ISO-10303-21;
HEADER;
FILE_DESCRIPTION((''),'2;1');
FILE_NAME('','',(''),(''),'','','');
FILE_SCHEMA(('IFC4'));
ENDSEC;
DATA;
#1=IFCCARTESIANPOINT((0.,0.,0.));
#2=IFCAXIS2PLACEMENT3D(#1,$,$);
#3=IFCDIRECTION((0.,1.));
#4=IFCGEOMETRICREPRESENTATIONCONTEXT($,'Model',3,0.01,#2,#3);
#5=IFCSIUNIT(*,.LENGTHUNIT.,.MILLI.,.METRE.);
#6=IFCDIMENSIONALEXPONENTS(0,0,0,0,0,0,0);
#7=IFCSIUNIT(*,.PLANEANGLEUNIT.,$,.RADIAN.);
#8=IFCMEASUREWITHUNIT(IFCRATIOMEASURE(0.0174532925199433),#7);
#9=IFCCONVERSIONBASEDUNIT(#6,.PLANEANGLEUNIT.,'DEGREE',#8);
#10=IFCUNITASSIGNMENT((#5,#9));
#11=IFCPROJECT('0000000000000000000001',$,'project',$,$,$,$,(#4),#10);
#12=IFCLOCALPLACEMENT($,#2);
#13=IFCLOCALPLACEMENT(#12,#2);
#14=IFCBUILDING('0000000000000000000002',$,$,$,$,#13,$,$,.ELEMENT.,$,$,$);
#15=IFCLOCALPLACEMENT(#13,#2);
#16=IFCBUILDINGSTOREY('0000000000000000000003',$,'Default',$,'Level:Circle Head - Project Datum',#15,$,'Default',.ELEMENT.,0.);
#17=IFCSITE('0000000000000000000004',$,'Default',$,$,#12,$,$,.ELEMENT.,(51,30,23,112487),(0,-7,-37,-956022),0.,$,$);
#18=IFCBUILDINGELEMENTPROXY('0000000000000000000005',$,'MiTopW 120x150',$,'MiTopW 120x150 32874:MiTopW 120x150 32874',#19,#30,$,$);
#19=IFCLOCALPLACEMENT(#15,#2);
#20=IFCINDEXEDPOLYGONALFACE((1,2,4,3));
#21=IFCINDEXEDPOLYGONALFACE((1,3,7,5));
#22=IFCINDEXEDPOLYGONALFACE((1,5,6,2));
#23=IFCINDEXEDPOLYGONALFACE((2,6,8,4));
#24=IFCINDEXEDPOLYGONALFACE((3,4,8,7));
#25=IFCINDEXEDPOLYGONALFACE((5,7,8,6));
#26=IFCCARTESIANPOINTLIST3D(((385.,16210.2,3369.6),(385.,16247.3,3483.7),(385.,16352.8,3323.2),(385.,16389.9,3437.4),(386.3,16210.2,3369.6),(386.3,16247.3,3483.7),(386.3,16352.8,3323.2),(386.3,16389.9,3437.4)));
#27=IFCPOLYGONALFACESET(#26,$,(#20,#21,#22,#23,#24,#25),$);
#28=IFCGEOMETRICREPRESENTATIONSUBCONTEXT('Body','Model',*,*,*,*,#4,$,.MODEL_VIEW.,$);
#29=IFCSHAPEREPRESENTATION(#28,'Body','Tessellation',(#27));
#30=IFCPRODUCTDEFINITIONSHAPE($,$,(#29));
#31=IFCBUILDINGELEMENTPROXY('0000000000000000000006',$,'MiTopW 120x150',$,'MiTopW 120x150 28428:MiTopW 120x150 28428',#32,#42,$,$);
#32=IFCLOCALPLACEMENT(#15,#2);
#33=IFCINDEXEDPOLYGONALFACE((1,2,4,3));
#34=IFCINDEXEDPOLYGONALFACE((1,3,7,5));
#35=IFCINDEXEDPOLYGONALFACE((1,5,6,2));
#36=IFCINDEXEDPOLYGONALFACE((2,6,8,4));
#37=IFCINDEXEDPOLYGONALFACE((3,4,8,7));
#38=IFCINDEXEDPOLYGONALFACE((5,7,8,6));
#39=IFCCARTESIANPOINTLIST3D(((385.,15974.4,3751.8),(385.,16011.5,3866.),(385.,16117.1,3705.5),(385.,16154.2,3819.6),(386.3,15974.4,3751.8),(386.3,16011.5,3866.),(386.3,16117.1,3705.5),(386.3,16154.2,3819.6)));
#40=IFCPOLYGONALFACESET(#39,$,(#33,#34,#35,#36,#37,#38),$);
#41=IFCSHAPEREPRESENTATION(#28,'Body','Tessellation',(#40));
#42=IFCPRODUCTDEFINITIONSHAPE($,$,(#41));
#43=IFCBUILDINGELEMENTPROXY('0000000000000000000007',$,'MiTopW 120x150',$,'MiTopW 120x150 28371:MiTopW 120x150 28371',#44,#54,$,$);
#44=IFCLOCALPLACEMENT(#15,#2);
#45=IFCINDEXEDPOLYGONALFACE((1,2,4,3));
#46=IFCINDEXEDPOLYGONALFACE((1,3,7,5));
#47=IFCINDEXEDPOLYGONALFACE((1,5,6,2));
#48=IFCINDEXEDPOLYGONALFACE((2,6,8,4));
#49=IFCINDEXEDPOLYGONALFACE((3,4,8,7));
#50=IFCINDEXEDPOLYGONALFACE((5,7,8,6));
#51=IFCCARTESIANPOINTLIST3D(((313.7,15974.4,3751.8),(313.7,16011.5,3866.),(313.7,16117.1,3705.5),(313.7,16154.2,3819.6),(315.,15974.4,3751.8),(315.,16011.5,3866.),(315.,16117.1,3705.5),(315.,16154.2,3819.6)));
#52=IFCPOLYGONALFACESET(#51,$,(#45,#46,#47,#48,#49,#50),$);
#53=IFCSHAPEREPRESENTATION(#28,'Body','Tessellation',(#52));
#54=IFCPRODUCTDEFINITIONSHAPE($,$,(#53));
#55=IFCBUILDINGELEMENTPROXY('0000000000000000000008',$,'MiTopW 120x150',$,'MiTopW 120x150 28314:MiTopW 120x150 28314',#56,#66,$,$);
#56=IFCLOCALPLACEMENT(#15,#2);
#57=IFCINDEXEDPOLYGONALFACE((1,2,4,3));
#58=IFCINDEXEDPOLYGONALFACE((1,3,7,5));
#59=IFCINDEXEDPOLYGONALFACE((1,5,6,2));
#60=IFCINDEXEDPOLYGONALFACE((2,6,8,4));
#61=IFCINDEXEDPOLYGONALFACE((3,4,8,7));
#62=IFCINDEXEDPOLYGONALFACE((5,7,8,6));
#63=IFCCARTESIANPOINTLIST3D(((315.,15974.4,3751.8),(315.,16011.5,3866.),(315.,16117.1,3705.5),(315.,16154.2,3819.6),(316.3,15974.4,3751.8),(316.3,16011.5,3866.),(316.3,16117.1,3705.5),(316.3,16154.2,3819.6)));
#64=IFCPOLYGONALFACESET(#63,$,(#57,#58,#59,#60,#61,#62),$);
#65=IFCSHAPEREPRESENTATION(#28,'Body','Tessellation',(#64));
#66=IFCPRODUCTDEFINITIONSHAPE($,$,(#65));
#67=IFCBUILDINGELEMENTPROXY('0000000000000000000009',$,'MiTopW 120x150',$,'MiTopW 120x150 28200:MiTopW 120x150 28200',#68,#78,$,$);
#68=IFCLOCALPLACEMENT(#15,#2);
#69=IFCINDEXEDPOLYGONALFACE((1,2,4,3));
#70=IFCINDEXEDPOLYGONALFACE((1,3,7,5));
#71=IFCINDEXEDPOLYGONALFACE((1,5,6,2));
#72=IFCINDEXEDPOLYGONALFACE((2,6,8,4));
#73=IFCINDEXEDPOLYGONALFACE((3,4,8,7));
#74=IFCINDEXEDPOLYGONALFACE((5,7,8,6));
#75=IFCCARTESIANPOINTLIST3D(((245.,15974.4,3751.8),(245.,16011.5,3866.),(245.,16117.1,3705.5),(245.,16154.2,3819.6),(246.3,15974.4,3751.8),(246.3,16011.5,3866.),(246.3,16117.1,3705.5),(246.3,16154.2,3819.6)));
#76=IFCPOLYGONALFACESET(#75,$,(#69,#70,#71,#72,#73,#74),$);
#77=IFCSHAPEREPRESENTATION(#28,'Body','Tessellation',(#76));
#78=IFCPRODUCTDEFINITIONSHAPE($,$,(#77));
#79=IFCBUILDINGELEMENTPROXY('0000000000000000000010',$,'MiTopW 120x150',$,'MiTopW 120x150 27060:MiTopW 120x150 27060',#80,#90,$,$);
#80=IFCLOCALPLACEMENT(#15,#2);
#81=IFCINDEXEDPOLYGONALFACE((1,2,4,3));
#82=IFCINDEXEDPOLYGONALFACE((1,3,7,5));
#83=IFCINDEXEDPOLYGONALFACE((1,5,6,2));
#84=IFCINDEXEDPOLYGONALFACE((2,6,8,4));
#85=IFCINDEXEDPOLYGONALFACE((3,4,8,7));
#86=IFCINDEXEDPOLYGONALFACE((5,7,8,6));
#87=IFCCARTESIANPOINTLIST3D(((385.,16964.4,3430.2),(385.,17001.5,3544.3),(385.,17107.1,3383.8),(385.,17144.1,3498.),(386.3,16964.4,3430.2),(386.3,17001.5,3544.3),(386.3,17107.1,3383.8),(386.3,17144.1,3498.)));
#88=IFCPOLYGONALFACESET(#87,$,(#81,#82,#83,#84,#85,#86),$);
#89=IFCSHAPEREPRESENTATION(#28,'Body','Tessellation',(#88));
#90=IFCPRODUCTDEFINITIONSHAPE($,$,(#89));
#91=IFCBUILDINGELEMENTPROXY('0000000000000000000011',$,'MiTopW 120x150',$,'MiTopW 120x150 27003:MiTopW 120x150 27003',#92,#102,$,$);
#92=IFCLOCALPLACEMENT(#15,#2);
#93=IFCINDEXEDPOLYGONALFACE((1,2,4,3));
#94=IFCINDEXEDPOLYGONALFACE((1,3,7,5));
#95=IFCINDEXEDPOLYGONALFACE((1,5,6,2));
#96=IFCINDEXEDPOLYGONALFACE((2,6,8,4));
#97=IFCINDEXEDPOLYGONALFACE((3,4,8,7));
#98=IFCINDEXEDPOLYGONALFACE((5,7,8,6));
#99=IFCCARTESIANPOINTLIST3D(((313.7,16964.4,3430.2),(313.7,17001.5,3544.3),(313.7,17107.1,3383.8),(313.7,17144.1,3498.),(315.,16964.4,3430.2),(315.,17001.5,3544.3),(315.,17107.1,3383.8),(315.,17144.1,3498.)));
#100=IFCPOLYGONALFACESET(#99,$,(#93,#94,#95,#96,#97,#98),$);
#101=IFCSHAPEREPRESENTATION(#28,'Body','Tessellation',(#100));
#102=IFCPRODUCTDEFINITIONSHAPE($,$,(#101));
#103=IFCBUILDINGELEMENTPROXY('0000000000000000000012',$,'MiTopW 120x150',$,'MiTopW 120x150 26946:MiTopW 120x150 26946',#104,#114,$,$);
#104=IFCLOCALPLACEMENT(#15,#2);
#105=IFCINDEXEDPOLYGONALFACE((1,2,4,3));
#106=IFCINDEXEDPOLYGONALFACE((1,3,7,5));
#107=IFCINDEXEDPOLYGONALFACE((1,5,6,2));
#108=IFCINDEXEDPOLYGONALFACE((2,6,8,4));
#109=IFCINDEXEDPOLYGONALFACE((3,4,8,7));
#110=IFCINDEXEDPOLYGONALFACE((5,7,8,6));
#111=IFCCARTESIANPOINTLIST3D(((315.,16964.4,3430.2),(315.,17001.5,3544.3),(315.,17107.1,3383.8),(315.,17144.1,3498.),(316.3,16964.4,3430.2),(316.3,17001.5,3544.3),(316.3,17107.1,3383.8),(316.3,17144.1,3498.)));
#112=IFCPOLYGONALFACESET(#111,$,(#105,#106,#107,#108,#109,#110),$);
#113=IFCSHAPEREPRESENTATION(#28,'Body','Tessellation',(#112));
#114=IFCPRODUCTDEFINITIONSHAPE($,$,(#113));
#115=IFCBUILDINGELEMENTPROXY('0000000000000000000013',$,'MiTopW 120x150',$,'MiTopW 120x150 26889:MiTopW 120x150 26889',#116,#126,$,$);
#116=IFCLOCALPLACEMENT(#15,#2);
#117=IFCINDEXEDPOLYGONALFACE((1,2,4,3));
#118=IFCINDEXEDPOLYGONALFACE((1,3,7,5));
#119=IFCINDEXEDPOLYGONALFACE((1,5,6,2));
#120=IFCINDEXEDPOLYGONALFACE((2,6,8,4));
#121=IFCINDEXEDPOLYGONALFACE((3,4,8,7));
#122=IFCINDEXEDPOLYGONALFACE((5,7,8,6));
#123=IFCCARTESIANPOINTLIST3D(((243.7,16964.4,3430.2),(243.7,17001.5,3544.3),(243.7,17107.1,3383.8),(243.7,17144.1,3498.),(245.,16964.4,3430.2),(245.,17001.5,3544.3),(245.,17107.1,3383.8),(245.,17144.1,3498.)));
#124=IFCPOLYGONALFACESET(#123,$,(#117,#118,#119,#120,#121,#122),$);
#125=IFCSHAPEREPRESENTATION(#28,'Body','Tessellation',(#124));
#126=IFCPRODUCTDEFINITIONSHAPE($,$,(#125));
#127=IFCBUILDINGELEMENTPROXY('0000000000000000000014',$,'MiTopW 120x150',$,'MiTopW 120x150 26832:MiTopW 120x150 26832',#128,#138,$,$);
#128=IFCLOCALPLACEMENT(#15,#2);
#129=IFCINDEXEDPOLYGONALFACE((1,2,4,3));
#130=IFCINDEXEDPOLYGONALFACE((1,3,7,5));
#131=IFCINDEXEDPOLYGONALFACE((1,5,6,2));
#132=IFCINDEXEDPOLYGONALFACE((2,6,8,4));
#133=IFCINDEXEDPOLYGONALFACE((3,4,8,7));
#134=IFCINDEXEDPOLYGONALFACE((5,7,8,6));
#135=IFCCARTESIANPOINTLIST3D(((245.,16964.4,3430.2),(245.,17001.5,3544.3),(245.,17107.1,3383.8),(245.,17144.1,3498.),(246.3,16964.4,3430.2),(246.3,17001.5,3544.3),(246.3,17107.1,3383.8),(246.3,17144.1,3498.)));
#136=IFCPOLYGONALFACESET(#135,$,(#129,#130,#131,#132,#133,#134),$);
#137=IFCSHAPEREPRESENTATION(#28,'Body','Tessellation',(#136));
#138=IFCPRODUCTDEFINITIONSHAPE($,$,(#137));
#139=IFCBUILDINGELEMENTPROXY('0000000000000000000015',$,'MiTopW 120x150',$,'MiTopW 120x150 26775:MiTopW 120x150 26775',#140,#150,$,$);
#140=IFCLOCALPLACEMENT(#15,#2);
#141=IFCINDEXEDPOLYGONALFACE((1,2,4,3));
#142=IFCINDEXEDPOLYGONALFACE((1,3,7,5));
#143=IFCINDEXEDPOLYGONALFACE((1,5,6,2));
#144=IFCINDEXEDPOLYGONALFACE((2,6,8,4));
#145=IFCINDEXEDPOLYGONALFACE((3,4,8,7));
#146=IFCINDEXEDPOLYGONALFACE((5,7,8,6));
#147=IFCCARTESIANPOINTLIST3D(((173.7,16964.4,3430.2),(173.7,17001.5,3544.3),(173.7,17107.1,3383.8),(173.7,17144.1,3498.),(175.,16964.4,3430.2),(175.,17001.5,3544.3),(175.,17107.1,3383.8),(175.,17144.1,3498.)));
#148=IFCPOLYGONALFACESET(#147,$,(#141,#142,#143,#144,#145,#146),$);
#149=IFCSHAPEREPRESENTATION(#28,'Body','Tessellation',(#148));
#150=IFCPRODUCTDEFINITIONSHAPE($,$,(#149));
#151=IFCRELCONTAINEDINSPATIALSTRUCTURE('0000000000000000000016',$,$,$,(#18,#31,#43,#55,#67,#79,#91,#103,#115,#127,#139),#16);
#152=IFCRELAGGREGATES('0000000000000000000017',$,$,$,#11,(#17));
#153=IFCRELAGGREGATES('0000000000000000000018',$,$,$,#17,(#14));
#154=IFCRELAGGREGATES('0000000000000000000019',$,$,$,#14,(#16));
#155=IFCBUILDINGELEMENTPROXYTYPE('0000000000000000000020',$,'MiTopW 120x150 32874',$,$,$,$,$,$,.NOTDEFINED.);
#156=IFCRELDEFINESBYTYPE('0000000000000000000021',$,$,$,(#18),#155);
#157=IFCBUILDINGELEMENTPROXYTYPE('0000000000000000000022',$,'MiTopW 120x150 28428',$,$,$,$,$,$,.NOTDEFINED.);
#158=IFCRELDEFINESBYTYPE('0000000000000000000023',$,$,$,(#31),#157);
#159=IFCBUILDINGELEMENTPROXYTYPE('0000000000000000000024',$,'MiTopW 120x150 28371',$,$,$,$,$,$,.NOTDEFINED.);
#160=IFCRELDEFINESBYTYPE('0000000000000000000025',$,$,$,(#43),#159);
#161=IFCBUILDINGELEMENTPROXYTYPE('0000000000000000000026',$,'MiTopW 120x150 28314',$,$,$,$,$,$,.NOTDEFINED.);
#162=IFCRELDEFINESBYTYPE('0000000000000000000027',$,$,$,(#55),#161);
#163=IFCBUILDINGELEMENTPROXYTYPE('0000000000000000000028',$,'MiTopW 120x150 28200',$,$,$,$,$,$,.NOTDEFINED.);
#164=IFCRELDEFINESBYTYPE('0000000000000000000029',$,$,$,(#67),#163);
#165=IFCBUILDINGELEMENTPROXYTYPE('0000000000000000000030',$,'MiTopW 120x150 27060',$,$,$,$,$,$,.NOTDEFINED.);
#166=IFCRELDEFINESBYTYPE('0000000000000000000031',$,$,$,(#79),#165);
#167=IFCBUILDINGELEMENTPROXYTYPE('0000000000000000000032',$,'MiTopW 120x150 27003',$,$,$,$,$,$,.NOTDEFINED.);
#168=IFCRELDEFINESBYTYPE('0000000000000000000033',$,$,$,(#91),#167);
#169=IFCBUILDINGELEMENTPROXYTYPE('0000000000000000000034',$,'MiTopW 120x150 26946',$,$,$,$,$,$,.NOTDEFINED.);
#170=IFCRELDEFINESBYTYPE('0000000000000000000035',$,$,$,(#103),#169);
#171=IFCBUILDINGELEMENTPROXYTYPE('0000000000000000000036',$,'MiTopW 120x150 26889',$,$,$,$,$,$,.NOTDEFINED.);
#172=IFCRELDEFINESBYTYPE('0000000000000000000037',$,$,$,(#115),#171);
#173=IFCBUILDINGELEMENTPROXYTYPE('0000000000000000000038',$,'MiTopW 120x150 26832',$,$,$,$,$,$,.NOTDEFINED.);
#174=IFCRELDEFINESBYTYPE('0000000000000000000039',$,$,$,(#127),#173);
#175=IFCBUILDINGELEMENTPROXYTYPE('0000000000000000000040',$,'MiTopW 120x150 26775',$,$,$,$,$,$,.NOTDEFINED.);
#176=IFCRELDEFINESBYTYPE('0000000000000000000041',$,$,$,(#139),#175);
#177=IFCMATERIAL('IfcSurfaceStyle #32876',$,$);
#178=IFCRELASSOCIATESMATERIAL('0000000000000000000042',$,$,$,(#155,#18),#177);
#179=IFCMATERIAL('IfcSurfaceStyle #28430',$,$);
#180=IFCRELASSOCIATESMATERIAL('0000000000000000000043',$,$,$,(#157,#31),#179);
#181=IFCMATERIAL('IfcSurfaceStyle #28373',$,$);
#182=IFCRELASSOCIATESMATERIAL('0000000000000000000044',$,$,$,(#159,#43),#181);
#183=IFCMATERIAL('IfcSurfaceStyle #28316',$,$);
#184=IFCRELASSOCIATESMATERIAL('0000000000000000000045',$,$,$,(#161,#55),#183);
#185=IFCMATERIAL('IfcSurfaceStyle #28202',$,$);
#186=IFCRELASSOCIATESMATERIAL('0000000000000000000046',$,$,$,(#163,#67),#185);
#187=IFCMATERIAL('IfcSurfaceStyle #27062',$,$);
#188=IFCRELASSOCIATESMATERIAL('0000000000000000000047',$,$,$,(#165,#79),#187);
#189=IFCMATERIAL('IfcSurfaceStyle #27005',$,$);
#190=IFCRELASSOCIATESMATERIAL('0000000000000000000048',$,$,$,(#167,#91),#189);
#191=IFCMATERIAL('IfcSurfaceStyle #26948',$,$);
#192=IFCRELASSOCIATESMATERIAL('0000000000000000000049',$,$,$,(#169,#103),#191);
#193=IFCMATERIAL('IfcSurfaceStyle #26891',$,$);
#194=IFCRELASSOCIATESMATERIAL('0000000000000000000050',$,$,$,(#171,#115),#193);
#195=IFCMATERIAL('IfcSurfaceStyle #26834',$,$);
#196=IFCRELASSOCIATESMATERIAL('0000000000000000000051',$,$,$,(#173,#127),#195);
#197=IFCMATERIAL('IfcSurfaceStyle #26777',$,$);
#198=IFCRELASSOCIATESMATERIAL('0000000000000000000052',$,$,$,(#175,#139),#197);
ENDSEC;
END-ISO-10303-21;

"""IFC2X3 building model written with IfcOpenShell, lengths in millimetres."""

from ifc_helpers import new_model, entity, si_unit, converted_unit, direction, frame, origin, place, context, subcontext, project, spatial, polyline, outline, extrude, source, transform, mapped, material, type_object, type_shapes, element, save


model = new_model("IFC2X3")

# Units and contexts
model_context = context("Model", 3, precision=0.01, world=origin(), true_north=direction((0.0, 1.0)))
body_context = subcontext(model_context, "Body", "Model", "MODEL_VIEW")
ifc_project = project(units=[si_unit("LENGTHUNIT", "METRE", prefix="MILLI"), converted_unit("PLANEANGLEUNIT", "DEGREE", entity("IfcRatioMeasure", 0.0174532925199433), si_unit("PLANEANGLEUNIT", "RADIAN"), dimensions=[0, 0, 0, 0, 0, 0, 0])], contexts=[model_context])

# Site, building, storey
site_placement = place(None, origin())
site = spatial("IfcSite", under=ifc_project, at=site_placement, Name="Default", CompositionType="ELEMENT", RefLatitude=(51, 30, 23, 112487), RefLongitude=(0, -7, -37, -956022), RefElevation=0.0)
building_placement = place(site_placement, origin())
building = spatial("IfcBuilding", under=site, at=building_placement, CompositionType="ELEMENT")
storey_placement = place(building_placement, origin())
storey = spatial("IfcBuildingStorey", under=building, at=storey_placement, Name="Default", ObjectType="Level:Circle Head - Project Datum", LongName="Default", CompositionType="ELEMENT", Elevation=0.0)

# Building element proxies
ifc_material_1 = material(Name="IfcSurfaceStyle #32876")
building_element_proxy_type_1 = type_object("IfcBuildingElementProxyType", Name="MiTopW 120x150 32874", PredefinedType="NOTDEFINED", material=ifc_material_1)
shared_shape_1 = source(origin(), body_context, "Body", "SweptSolid", [
    extrude(outline(polyline([(-75.0, -60.0), (75.0, -60.0), (75.0, 60.0), (-75.0, 60.0), (-75.0, -60.0)])), frame((75.0, 60.0, 0.0), z_axis=(0.0, 0.0, 1.0), x_axis=(-1.0, 0.0, 0.0)), (0.0, 0.0, 1.0), 1.3),
])
type_shapes(building_element_proxy_type_1, [shared_shape_1])
proxy_1_placement = place(building_placement, frame((386.3, 16352.8, 3323.2), z_axis=(-1.0, 0.0, 0.0), x_axis=(0.0, -0.951057, 0.309017)))
element("IfcBuildingElementProxy", 1, at=proxy_1_placement, inside=storey, type_object=building_element_proxy_type_1, material=ifc_material_1, Name="MiTopW 120x150", ObjectType="MiTopW 120x150 32874:MiTopW 120x150 32874", context=body_context, shape_type="MappedRepresentation", body=[
    mapped(shared_shape_1, transform((0.0, 0.0, 0.0), scale=1.0)),
])
ifc_material_2 = material(Name="IfcSurfaceStyle #28430")
building_element_proxy_type_2 = type_object("IfcBuildingElementProxyType", Name="MiTopW 120x150 28428", PredefinedType="NOTDEFINED", material=ifc_material_2)
shared_shape_2 = source(origin(), body_context, "Body", "SweptSolid", [
    extrude(outline(polyline([(-75.0, -60.0), (75.0, -60.0), (75.0, 60.0), (-75.0, 60.0), (-75.0, -60.0)])), frame((75.0, 60.0, 0.0), z_axis=(0.0, 0.0, 1.0), x_axis=(-1.0, 0.0, 0.0)), (0.0, 0.0, 1.0), 1.3),
])
type_shapes(building_element_proxy_type_2, [shared_shape_2])
proxy_2_placement = place(building_placement, frame((386.3, 16117.1, 3705.5), z_axis=(-1.0, 0.0, 0.0), x_axis=(0.0, -0.951057, 0.309017)))
element("IfcBuildingElementProxy", 2, at=proxy_2_placement, inside=storey, type_object=building_element_proxy_type_2, material=ifc_material_2, Name="MiTopW 120x150", ObjectType="MiTopW 120x150 28428:MiTopW 120x150 28428", context=body_context, shape_type="MappedRepresentation", body=[
    mapped(shared_shape_2, transform((0.0, 0.0, 0.0), scale=1.0)),
])
ifc_material_3 = material(Name="IfcSurfaceStyle #28373")
building_element_proxy_type_3 = type_object("IfcBuildingElementProxyType", Name="MiTopW 120x150 28371", PredefinedType="NOTDEFINED", material=ifc_material_3)
shared_shape_3 = source(origin(), body_context, "Body", "SweptSolid", [
    extrude(outline(polyline([(-75.0, -60.0), (75.0, -60.0), (75.0, 60.0), (-75.0, 60.0), (-75.0, -60.0)])), frame((75.0, 60.0, 0.0), z_axis=(0.0, 0.0, 1.0), x_axis=(-1.0, 0.0, 0.0)), (0.0, 0.0, 1.0), 1.3),
])
type_shapes(building_element_proxy_type_3, [shared_shape_3])
proxy_3_placement = place(building_placement, frame((315.0, 16117.1, 3705.5), z_axis=(-1.0, 0.0, 0.0), x_axis=(0.0, -0.951057, 0.309017)))
element("IfcBuildingElementProxy", 3, at=proxy_3_placement, inside=storey, type_object=building_element_proxy_type_3, material=ifc_material_3, Name="MiTopW 120x150", ObjectType="MiTopW 120x150 28371:MiTopW 120x150 28371", context=body_context, shape_type="MappedRepresentation", body=[
    mapped(shared_shape_3, transform((0.0, 0.0, 0.0), scale=1.0)),
])
ifc_material_4 = material(Name="IfcSurfaceStyle #28316")
building_element_proxy_type_4 = type_object("IfcBuildingElementProxyType", Name="MiTopW 120x150 28314", PredefinedType="NOTDEFINED", material=ifc_material_4)
shared_shape_4 = source(origin(), body_context, "Body", "SweptSolid", [
    extrude(outline(polyline([(-75.0, -60.0), (75.0, -60.0), (75.0, 60.0), (-75.0, 60.0), (-75.0, -60.0)])), frame((75.0, 60.0, 0.0), z_axis=(0.0, 0.0, 1.0), x_axis=(-1.0, 0.0, 0.0)), (0.0, 0.0, 1.0), 1.3),
])
type_shapes(building_element_proxy_type_4, [shared_shape_4])
proxy_4_placement = place(building_placement, frame((316.3, 16117.1, 3705.5), z_axis=(-1.0, 0.0, 0.0), x_axis=(0.0, -0.951057, 0.309017)))
element("IfcBuildingElementProxy", 4, at=proxy_4_placement, inside=storey, type_object=building_element_proxy_type_4, material=ifc_material_4, Name="MiTopW 120x150", ObjectType="MiTopW 120x150 28314:MiTopW 120x150 28314", context=body_context, shape_type="MappedRepresentation", body=[
    mapped(shared_shape_4, transform((0.0, 0.0, 0.0), scale=1.0)),
])
ifc_material_5 = material(Name="IfcSurfaceStyle #28202")
building_element_proxy_type_5 = type_object("IfcBuildingElementProxyType", Name="MiTopW 120x150 28200", PredefinedType="NOTDEFINED", material=ifc_material_5)
shared_shape_5 = source(origin(), body_context, "Body", "SweptSolid", [
    extrude(outline(polyline([(-75.0, -60.0), (75.0, -60.0), (75.0, 60.0), (-75.0, 60.0), (-75.0, -60.0)])), frame((75.0, 60.0, 0.0), z_axis=(0.0, 0.0, 1.0), x_axis=(-1.0, 0.0, 0.0)), (0.0, 0.0, 1.0), 1.3),
])
type_shapes(building_element_proxy_type_5, [shared_shape_5])
proxy_5_placement = place(building_placement, frame((246.3, 16117.1, 3705.5), z_axis=(-1.0, 0.0, 0.0), x_axis=(0.0, -0.951057, 0.309017)))
element("IfcBuildingElementProxy", 5, at=proxy_5_placement, inside=storey, type_object=building_element_proxy_type_5, material=ifc_material_5, Name="MiTopW 120x150", ObjectType="MiTopW 120x150 28200:MiTopW 120x150 28200", context=body_context, shape_type="MappedRepresentation", body=[
    mapped(shared_shape_5, transform((0.0, 0.0, 0.0), scale=1.0)),
])
ifc_material_6 = material(Name="IfcSurfaceStyle #27062")
building_element_proxy_type_6 = type_object("IfcBuildingElementProxyType", Name="MiTopW 120x150 27060", PredefinedType="NOTDEFINED", material=ifc_material_6)
shared_shape_6 = source(origin(), body_context, "Body", "SweptSolid", [
    extrude(outline(polyline([(-75.0, -60.0), (75.0, -60.0), (75.0, 60.0), (-75.0, 60.0), (-75.0, -60.0)])), frame((75.0, 60.0, 0.0), z_axis=(0.0, 0.0, 1.0), x_axis=(-1.0, 0.0, 0.0)), (0.0, 0.0, 1.0), 1.3),
])
type_shapes(building_element_proxy_type_6, [shared_shape_6])
proxy_6_placement = place(building_placement, frame((386.3, 17107.1, 3383.8), z_axis=(-1.0, 0.0, 0.0), x_axis=(0.0, -0.951057, 0.309017)))
element("IfcBuildingElementProxy", 6, at=proxy_6_placement, inside=storey, type_object=building_element_proxy_type_6, material=ifc_material_6, Name="MiTopW 120x150", ObjectType="MiTopW 120x150 27060:MiTopW 120x150 27060", context=body_context, shape_type="MappedRepresentation", body=[
    mapped(shared_shape_6, transform((0.0, 0.0, 0.0), scale=1.0)),
])
ifc_material_7 = material(Name="IfcSurfaceStyle #27005")
building_element_proxy_type_7 = type_object("IfcBuildingElementProxyType", Name="MiTopW 120x150 27003", PredefinedType="NOTDEFINED", material=ifc_material_7)
shared_shape_7 = source(origin(), body_context, "Body", "SweptSolid", [
    extrude(outline(polyline([(-75.0, -60.0), (75.0, -60.0), (75.0, 60.0), (-75.0, 60.0), (-75.0, -60.0)])), frame((75.0, 60.0, 0.0), z_axis=(0.0, 0.0, 1.0), x_axis=(-1.0, 0.0, 0.0)), (0.0, 0.0, 1.0), 1.3),
])
type_shapes(building_element_proxy_type_7, [shared_shape_7])
proxy_7_placement = place(building_placement, frame((315.0, 17107.1, 3383.8), z_axis=(-1.0, 0.0, 0.0), x_axis=(0.0, -0.951057, 0.309017)))
element("IfcBuildingElementProxy", 7, at=proxy_7_placement, inside=storey, type_object=building_element_proxy_type_7, material=ifc_material_7, Name="MiTopW 120x150", ObjectType="MiTopW 120x150 27003:MiTopW 120x150 27003", context=body_context, shape_type="MappedRepresentation", body=[
    mapped(shared_shape_7, transform((0.0, 0.0, 0.0), scale=1.0)),
])
ifc_material_8 = material(Name="IfcSurfaceStyle #26948")
building_element_proxy_type_8 = type_object("IfcBuildingElementProxyType", Name="MiTopW 120x150 26946", PredefinedType="NOTDEFINED", material=ifc_material_8)
shared_shape_8 = source(origin(), body_context, "Body", "SweptSolid", [
    extrude(outline(polyline([(-75.0, -60.0), (75.0, -60.0), (75.0, 60.0), (-75.0, 60.0), (-75.0, -60.0)])), frame((75.0, 60.0, 0.0), z_axis=(0.0, 0.0, 1.0), x_axis=(-1.0, 0.0, 0.0)), (0.0, 0.0, 1.0), 1.3),
])
type_shapes(building_element_proxy_type_8, [shared_shape_8])
proxy_8_placement = place(building_placement, frame((316.3, 17107.1, 3383.8), z_axis=(-1.0, 0.0, 0.0), x_axis=(0.0, -0.951057, 0.309017)))
element("IfcBuildingElementProxy", 8, at=proxy_8_placement, inside=storey, type_object=building_element_proxy_type_8, material=ifc_material_8, Name="MiTopW 120x150", ObjectType="MiTopW 120x150 26946:MiTopW 120x150 26946", context=body_context, shape_type="MappedRepresentation", body=[
    mapped(shared_shape_8, transform((0.0, 0.0, 0.0), scale=1.0)),
])
ifc_material_9 = material(Name="IfcSurfaceStyle #26891")
building_element_proxy_type_9 = type_object("IfcBuildingElementProxyType", Name="MiTopW 120x150 26889", PredefinedType="NOTDEFINED", material=ifc_material_9)
shared_shape_9 = source(origin(), body_context, "Body", "SweptSolid", [
    extrude(outline(polyline([(-75.0, -60.0), (75.0, -60.0), (75.0, 60.0), (-75.0, 60.0), (-75.0, -60.0)])), frame((75.0, 60.0, 0.0), z_axis=(0.0, 0.0, 1.0), x_axis=(-1.0, 0.0, 0.0)), (0.0, 0.0, 1.0), 1.3),
])
type_shapes(building_element_proxy_type_9, [shared_shape_9])
proxy_9_placement = place(building_placement, frame((245.0, 17107.1, 3383.8), z_axis=(-1.0, 0.0, 0.0), x_axis=(0.0, -0.951057, 0.309017)))
element("IfcBuildingElementProxy", 9, at=proxy_9_placement, inside=storey, type_object=building_element_proxy_type_9, material=ifc_material_9, Name="MiTopW 120x150", ObjectType="MiTopW 120x150 26889:MiTopW 120x150 26889", context=body_context, shape_type="MappedRepresentation", body=[
    mapped(shared_shape_9, transform((0.0, 0.0, 0.0), scale=1.0)),
])
ifc_material_10 = material(Name="IfcSurfaceStyle #26834")
building_element_proxy_type_10 = type_object("IfcBuildingElementProxyType", Name="MiTopW 120x150 26832", PredefinedType="NOTDEFINED", material=ifc_material_10)
shared_shape_10 = source(origin(), body_context, "Body", "SweptSolid", [
    extrude(outline(polyline([(-75.0, -60.0), (75.0, -60.0), (75.0, 60.0), (-75.0, 60.0), (-75.0, -60.0)])), frame((75.0, 60.0, 0.0), z_axis=(0.0, 0.0, 1.0), x_axis=(-1.0, 0.0, 0.0)), (0.0, 0.0, 1.0), 1.3),
])
type_shapes(building_element_proxy_type_10, [shared_shape_10])
proxy_10_placement = place(building_placement, frame((246.3, 17107.1, 3383.8), z_axis=(-1.0, 0.0, 0.0), x_axis=(0.0, -0.951057, 0.309017)))
element("IfcBuildingElementProxy", 10, at=proxy_10_placement, inside=storey, type_object=building_element_proxy_type_10, material=ifc_material_10, Name="MiTopW 120x150", ObjectType="MiTopW 120x150 26832:MiTopW 120x150 26832", context=body_context, shape_type="MappedRepresentation", body=[
    mapped(shared_shape_10, transform((0.0, 0.0, 0.0), scale=1.0)),
])
ifc_material_11 = material(Name="IfcSurfaceStyle #26777")
building_element_proxy_type_11 = type_object("IfcBuildingElementProxyType", Name="MiTopW 120x150 26775", PredefinedType="NOTDEFINED", material=ifc_material_11)
shared_shape_11 = source(origin(), body_context, "Body", "SweptSolid", [
    extrude(outline(polyline([(-75.0, -60.0), (75.0, -60.0), (75.0, 60.0), (-75.0, 60.0), (-75.0, -60.0)])), frame((75.0, 60.0, 0.0), z_axis=(0.0, 0.0, 1.0), x_axis=(-1.0, 0.0, 0.0)), (0.0, 0.0, 1.0), 1.3),
])
type_shapes(building_element_proxy_type_11, [shared_shape_11])
proxy_11_placement = place(building_placement, frame((175.0, 17107.1, 3383.8), z_axis=(-1.0, 0.0, 0.0), x_axis=(0.0, -0.951057, 0.309017)))
element("IfcBuildingElementProxy", 11, at=proxy_11_placement, inside=storey, type_object=building_element_proxy_type_11, material=ifc_material_11, Name="MiTopW 120x150", ObjectType="MiTopW 120x150 26775:MiTopW 120x150 26775", context=body_context, shape_type="MappedRepresentation", body=[
    mapped(shared_shape_11, transform((0.0, 0.0, 0.0), scale=1.0)),
])

save(model, "model.ifc")
